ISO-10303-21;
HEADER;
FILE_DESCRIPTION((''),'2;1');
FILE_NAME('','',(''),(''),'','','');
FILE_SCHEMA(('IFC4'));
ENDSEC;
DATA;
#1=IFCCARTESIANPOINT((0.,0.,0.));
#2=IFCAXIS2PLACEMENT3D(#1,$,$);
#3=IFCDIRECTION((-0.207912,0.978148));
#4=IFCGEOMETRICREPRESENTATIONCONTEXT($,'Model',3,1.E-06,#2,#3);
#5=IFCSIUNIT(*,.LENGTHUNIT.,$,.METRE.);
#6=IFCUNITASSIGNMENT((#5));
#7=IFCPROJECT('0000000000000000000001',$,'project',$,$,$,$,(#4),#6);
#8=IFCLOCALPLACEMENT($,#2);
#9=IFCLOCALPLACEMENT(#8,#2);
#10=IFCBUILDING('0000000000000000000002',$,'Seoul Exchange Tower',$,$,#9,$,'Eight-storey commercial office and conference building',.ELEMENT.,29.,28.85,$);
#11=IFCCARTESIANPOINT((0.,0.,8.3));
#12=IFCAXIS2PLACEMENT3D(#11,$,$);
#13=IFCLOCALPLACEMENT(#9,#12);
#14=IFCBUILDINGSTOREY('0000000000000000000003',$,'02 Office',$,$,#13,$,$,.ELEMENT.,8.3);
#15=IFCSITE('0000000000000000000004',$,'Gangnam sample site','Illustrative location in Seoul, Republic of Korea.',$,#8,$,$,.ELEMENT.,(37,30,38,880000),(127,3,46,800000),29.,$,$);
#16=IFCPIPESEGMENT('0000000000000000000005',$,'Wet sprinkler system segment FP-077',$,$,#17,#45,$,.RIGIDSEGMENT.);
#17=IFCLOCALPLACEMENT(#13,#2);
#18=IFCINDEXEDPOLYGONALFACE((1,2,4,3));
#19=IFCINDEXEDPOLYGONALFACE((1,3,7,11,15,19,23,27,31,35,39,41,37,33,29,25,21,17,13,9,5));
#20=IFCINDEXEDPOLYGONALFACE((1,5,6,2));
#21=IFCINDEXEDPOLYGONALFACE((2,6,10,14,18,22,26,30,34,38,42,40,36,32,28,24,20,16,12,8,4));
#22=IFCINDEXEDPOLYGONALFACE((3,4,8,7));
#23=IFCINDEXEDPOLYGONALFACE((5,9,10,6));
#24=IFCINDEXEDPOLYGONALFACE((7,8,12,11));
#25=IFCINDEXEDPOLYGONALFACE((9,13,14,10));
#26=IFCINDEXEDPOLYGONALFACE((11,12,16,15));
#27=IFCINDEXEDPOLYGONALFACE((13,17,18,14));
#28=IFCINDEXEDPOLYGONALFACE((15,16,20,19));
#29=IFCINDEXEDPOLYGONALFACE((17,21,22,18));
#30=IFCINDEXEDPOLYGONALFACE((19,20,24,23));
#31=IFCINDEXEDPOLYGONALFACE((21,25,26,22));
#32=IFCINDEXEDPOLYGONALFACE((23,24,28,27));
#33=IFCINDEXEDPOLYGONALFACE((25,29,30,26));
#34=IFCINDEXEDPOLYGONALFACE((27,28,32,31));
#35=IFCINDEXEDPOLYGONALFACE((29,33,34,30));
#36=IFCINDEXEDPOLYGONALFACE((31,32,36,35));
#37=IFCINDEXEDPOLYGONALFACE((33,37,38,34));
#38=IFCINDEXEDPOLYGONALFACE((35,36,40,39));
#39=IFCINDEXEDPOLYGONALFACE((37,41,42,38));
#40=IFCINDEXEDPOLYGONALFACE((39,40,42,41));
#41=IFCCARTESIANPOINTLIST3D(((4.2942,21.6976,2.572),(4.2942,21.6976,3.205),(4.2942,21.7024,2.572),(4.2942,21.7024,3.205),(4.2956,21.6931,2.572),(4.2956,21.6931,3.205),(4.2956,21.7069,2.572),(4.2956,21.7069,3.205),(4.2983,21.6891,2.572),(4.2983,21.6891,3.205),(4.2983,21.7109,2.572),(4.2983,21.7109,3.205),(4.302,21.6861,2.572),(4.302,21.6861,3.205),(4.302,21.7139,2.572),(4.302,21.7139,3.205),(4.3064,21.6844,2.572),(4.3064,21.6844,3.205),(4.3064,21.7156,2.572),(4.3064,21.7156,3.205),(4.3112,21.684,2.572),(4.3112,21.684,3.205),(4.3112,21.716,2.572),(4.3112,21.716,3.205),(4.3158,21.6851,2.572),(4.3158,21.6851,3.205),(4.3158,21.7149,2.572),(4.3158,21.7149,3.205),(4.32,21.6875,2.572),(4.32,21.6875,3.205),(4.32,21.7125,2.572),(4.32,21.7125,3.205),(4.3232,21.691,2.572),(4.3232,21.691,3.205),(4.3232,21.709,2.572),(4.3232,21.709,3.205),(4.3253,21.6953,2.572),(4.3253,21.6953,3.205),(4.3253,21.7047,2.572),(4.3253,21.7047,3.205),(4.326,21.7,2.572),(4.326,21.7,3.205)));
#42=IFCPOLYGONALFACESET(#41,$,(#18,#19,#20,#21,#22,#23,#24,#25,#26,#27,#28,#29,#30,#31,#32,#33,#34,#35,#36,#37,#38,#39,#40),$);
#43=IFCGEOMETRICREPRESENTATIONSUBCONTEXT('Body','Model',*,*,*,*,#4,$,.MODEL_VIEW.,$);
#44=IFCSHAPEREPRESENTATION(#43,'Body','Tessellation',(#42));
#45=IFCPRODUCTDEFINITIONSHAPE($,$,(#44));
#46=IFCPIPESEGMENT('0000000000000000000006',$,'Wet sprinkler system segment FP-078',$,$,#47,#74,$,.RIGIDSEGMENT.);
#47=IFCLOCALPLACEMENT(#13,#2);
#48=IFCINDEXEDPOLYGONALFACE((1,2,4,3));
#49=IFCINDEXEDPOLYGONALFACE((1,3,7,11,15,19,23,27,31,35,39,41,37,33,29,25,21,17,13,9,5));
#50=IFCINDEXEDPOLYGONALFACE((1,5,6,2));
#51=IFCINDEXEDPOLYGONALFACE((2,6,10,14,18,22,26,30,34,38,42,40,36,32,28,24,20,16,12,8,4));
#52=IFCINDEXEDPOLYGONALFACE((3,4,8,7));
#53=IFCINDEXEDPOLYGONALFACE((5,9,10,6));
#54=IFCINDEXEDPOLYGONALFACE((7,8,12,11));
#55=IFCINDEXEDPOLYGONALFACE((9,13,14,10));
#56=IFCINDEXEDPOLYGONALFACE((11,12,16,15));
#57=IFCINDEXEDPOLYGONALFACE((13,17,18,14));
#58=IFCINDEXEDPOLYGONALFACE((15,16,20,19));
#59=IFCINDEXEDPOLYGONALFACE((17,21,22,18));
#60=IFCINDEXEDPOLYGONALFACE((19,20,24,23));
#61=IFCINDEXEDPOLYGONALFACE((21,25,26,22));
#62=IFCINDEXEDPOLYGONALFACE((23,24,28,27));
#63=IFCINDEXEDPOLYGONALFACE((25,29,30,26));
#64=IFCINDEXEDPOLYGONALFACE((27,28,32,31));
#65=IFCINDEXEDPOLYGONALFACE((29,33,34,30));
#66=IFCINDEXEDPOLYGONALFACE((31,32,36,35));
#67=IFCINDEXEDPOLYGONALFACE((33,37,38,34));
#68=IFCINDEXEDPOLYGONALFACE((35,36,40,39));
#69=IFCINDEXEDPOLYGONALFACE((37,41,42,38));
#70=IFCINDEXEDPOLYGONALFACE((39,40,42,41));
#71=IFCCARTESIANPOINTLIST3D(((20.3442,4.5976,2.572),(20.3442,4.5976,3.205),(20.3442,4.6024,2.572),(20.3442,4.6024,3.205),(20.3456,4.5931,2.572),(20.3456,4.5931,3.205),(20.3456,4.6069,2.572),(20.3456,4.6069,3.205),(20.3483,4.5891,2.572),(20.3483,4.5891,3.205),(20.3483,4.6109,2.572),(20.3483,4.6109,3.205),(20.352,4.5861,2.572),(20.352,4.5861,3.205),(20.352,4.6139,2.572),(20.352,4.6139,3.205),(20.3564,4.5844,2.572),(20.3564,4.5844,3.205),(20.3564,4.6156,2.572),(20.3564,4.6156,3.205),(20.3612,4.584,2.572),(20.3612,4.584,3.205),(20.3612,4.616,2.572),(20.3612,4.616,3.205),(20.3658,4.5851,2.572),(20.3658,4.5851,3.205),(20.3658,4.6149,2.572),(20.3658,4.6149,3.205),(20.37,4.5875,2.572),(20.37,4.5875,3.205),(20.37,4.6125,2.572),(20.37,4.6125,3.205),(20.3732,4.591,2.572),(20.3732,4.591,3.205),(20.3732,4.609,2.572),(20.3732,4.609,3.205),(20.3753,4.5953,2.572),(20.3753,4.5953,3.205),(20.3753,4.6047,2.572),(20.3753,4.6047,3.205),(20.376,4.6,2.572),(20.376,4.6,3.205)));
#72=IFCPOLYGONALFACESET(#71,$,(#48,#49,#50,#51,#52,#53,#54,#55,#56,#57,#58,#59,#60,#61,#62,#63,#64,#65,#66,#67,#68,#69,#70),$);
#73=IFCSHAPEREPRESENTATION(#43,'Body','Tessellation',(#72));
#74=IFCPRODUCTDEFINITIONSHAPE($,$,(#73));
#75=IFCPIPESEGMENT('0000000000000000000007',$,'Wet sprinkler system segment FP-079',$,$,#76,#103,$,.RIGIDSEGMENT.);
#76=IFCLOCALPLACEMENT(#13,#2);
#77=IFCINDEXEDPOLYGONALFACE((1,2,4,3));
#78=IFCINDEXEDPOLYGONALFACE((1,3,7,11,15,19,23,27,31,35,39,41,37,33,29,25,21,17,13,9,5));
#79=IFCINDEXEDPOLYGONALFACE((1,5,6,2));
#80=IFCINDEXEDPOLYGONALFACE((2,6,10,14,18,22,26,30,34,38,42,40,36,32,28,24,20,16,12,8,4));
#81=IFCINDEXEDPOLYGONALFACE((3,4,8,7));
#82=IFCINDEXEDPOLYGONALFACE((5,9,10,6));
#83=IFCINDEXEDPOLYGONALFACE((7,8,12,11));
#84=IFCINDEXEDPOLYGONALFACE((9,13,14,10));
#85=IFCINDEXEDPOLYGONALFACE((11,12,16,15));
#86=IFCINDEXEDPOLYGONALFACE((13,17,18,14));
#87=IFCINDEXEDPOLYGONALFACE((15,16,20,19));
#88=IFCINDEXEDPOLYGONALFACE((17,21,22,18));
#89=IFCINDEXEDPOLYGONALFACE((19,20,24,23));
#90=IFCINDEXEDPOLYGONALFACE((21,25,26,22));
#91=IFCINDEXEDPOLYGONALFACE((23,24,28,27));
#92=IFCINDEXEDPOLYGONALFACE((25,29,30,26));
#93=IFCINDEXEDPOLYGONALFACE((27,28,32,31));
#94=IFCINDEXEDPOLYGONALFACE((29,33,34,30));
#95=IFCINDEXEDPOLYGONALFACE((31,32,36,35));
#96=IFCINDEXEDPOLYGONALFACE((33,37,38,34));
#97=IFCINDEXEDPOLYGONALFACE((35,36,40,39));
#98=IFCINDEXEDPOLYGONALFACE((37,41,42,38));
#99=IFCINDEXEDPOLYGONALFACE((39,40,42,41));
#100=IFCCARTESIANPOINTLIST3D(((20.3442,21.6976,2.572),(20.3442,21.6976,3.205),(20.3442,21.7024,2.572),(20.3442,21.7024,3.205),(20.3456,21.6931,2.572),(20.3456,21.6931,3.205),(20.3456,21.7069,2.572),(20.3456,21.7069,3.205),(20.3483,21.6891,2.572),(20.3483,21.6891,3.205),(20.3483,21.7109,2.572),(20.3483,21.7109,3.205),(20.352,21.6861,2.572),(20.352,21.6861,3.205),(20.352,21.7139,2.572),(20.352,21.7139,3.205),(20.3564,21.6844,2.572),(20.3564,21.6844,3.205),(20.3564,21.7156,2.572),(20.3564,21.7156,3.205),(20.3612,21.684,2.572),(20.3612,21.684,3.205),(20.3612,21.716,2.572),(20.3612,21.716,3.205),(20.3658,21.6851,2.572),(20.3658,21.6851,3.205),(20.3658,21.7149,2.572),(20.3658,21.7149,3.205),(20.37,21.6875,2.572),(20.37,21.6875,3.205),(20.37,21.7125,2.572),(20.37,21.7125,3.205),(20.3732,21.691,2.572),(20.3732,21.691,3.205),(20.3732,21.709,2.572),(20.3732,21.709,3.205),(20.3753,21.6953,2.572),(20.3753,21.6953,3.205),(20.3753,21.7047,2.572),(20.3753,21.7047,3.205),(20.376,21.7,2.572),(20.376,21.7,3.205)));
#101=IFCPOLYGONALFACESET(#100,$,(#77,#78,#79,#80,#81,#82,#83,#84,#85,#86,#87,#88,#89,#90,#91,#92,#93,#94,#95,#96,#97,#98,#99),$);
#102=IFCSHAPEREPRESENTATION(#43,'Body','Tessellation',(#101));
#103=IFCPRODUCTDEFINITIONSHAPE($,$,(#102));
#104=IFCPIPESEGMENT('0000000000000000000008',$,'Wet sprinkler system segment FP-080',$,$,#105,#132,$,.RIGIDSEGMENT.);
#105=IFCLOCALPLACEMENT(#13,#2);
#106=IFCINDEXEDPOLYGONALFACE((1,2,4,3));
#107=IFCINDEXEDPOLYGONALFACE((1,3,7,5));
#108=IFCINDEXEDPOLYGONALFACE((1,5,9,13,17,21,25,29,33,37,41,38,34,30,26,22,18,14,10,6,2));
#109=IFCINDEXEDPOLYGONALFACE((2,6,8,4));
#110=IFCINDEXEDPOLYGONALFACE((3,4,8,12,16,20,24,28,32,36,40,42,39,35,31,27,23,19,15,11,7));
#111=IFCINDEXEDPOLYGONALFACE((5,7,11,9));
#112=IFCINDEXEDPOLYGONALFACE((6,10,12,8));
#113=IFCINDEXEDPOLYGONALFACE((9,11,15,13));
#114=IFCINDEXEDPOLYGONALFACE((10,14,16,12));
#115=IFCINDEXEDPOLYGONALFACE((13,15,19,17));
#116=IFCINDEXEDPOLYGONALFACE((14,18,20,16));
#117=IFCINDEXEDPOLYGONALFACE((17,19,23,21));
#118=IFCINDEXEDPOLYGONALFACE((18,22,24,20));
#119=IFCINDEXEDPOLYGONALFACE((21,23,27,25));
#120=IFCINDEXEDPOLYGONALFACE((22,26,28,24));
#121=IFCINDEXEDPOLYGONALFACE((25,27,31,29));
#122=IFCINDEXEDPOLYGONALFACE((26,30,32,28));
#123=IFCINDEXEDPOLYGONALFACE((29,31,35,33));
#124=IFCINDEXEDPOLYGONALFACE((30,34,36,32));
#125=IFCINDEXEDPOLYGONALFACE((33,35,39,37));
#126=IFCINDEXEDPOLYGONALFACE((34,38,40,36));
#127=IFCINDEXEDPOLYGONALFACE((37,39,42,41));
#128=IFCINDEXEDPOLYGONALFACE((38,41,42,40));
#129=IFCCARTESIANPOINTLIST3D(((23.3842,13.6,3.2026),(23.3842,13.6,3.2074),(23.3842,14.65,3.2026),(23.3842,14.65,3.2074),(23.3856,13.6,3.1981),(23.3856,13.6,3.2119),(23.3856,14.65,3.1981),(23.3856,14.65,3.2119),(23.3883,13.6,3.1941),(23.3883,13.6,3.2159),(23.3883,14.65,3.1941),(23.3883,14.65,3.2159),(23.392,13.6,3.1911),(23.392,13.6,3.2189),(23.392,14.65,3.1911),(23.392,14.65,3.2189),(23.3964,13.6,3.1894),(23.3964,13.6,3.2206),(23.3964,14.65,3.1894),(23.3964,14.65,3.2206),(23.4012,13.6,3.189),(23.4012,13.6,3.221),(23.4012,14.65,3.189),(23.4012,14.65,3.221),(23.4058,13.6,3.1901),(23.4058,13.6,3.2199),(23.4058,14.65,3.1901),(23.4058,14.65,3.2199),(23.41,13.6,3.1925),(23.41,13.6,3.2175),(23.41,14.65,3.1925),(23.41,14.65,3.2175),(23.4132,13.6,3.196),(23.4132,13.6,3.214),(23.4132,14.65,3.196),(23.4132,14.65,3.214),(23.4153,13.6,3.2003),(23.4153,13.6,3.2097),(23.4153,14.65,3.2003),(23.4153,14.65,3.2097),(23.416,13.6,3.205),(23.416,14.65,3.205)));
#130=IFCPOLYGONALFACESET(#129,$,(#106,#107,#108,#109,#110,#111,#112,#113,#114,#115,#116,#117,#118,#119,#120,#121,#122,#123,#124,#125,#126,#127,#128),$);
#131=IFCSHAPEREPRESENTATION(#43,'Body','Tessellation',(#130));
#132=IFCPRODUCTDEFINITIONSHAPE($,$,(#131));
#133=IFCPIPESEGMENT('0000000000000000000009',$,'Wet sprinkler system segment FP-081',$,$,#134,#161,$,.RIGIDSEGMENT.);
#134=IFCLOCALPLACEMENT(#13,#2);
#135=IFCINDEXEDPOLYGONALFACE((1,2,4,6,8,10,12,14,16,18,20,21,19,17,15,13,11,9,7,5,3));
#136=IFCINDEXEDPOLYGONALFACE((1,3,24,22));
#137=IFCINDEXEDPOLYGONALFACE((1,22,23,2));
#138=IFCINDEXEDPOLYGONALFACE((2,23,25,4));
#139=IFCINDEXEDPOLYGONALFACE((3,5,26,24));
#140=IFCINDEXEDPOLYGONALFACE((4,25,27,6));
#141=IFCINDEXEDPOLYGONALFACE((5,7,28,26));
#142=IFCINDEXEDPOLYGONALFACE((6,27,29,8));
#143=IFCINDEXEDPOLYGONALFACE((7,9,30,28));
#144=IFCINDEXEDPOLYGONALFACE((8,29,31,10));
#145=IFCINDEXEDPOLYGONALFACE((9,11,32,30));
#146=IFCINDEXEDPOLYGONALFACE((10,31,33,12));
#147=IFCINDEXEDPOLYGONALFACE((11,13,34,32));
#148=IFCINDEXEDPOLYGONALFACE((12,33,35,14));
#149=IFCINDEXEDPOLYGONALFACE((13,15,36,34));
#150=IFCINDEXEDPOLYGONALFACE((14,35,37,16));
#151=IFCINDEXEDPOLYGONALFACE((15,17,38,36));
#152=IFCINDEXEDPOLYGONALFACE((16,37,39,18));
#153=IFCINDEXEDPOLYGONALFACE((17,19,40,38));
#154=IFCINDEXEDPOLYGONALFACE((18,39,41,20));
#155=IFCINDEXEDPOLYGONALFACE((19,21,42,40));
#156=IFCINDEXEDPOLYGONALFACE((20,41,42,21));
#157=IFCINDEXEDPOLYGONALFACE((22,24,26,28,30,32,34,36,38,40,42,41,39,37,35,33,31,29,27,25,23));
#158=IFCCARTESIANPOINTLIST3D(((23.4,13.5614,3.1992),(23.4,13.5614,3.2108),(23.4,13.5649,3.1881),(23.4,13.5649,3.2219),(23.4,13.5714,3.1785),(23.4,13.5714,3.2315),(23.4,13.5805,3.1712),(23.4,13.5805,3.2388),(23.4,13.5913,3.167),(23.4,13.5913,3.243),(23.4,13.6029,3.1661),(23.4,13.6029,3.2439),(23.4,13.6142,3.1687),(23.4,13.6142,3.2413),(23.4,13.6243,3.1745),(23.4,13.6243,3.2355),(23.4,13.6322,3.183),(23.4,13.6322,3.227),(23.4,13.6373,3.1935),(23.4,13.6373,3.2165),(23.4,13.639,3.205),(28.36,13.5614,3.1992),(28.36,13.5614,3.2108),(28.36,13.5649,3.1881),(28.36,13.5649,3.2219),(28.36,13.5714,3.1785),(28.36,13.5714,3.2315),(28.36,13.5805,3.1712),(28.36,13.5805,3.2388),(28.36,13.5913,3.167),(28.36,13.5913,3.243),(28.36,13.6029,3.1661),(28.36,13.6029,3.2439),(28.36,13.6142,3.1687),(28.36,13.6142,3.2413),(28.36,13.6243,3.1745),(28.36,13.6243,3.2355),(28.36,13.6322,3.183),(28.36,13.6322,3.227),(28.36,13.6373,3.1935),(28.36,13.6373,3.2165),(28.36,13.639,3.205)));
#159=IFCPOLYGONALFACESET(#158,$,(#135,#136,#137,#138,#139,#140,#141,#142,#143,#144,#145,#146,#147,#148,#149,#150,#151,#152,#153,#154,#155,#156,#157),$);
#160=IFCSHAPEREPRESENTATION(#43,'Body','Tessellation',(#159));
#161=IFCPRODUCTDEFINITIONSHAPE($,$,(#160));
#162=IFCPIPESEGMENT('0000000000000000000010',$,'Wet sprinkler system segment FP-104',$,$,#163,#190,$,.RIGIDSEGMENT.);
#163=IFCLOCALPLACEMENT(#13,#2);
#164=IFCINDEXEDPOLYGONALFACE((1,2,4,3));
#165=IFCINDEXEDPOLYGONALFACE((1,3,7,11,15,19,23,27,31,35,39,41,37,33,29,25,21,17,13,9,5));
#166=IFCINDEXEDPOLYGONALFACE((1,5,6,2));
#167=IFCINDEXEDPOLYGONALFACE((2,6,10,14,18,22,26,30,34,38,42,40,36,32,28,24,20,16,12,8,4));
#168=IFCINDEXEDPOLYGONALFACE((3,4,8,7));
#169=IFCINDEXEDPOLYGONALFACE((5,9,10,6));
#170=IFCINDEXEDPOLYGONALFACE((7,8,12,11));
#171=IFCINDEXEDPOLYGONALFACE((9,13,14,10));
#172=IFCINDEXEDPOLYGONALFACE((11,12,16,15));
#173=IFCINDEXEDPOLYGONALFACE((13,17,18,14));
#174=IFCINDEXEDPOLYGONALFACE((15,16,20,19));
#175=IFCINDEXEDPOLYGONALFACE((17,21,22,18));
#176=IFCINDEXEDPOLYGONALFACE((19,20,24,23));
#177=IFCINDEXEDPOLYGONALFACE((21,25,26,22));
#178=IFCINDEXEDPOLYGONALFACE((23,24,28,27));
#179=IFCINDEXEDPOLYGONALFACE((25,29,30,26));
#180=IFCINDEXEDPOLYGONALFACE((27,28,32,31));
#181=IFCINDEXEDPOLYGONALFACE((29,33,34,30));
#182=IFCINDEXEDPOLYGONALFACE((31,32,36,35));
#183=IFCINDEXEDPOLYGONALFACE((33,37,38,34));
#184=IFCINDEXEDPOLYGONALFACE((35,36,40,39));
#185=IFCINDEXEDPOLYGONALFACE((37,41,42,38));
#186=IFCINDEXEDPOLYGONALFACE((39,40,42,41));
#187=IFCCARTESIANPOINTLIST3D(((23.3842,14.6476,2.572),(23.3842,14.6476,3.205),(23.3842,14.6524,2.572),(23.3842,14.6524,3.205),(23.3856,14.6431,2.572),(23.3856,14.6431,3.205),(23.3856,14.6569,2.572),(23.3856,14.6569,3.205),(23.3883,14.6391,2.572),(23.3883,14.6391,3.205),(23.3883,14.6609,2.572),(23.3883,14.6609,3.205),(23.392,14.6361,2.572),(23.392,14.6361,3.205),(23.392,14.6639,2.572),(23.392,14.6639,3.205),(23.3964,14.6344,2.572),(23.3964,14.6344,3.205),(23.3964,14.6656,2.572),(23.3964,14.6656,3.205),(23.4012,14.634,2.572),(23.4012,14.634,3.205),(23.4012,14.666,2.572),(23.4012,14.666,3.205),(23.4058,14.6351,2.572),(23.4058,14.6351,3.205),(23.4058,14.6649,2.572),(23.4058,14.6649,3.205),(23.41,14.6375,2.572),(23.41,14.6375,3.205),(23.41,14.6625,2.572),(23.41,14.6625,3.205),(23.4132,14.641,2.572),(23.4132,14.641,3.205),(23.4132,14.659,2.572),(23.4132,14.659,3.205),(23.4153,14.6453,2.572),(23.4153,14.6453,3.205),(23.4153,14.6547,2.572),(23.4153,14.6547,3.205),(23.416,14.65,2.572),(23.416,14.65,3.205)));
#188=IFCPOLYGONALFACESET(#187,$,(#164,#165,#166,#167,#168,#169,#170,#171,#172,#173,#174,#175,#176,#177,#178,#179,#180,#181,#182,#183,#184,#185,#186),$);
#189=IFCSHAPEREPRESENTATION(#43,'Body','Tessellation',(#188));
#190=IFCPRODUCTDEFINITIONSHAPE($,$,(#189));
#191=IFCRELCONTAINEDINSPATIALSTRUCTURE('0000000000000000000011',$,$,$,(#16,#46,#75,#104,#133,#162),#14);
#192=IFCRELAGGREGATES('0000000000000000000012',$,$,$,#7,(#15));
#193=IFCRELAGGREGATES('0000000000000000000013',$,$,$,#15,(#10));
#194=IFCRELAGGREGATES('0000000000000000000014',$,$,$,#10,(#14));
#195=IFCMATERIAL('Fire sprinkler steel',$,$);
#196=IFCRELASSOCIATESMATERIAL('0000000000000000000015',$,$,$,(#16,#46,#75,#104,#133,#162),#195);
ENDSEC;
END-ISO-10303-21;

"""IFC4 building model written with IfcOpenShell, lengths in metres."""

from ifc_helpers import new_model, si_unit, direction, frame, origin, place, context, subcontext, project, spatial, circle, extrude, material, element, save


model = new_model("IFC4")

# Units and contexts
model_context = context("Model", 3, precision=1e-06, world=origin(), true_north=direction((-0.207912, 0.978148)))
body_context = subcontext(model_context, "Body", "Model", "MODEL_VIEW")
ifc_project = project(units=[si_unit("LENGTHUNIT", "METRE")], contexts=[model_context])

# Site, building, storey
site_placement = place(None, origin())
site = spatial("IfcSite", under=ifc_project, at=site_placement, Name="Gangnam sample site", Description="Illustrative location in Seoul, Republic of Korea.", CompositionType="ELEMENT", RefLatitude=(37, 30, 38, 880000), RefLongitude=(127, 3, 46, 800000), RefElevation=29.0)
building_placement = place(site_placement, origin())
building = spatial("IfcBuilding", under=site, at=building_placement, Name="Seoul Exchange Tower", LongName="Eight-storey commercial office and conference building", CompositionType="ELEMENT", ElevationOfRefHeight=29.0, ElevationOfTerrain=28.85)
storey_placement = place(building_placement, frame((0.0, 0.0, 8.3)))
storey = spatial("IfcBuildingStorey", under=building, at=storey_placement, Name="02 Office", CompositionType="ELEMENT", Elevation=8.3)

# Shared definitions
ifc_material = material(Name="Fire sprinkler steel")
placement = place(storey_placement, origin())

# Pipe segments
element("IfcPipeSegment", 1, at=placement, inside=storey, material=ifc_material, Name="Wet sprinkler system segment FP-077", PredefinedType="RIGIDSEGMENT", context=body_context, shape_type="SweptSolid", body=[
    extrude(circle(Radius=0.016), frame((4.31, 21.7, 3.205), z_axis=(0.0, 0.0, -1.0), x_axis=(1.0, 0.0, 0.0)), (0.0, 0.0, 1.0), 0.633),
])
element("IfcPipeSegment", 2, at=placement, inside=storey, material=ifc_material, Name="Wet sprinkler system segment FP-078", PredefinedType="RIGIDSEGMENT", context=body_context, shape_type="SweptSolid", body=[
    extrude(circle(Radius=0.016), frame((20.36, 4.6, 3.205), z_axis=(0.0, 0.0, -1.0), x_axis=(1.0, 0.0, 0.0)), (0.0, 0.0, 1.0), 0.633),
])
element("IfcPipeSegment", 3, at=placement, inside=storey, material=ifc_material, Name="Wet sprinkler system segment FP-079", PredefinedType="RIGIDSEGMENT", context=body_context, shape_type="SweptSolid", body=[
    extrude(circle(Radius=0.016), frame((20.36, 21.7, 3.205), z_axis=(0.0, 0.0, -1.0), x_axis=(1.0, 0.0, 0.0)), (0.0, 0.0, 1.0), 0.633),
])
element("IfcPipeSegment", 4, at=placement, inside=storey, material=ifc_material, Name="Wet sprinkler system segment FP-080", PredefinedType="RIGIDSEGMENT", context=body_context, shape_type="SweptSolid", body=[
    extrude(circle(Radius=0.016), frame((23.4, 13.6, 3.205), z_axis=(0.0, 1.0, 0.0), x_axis=(1.0, 0.0, 0.0)), (0.0, 0.0, 1.0), 1.05),
])
element("IfcPipeSegment", 5, at=placement, inside=storey, material=ifc_material, Name="Wet sprinkler system segment FP-081", PredefinedType="RIGIDSEGMENT", context=body_context, shape_type="SweptSolid", body=[
    extrude(circle(Radius=0.039), frame((23.4, 13.6, 3.205), z_axis=(1.0, 0.0, 0.0), x_axis=(0.0, 1.0, 0.0)), (0.0, 0.0, 1.0), 4.96),
])
element("IfcPipeSegment", 6, at=placement, inside=storey, material=ifc_material, Name="Wet sprinkler system segment FP-104", PredefinedType="RIGIDSEGMENT", context=body_context, shape_type="SweptSolid", body=[
    extrude(circle(Radius=0.016), frame((23.4, 14.65, 3.205), z_axis=(0.0, 0.0, -1.0), x_axis=(1.0, 0.0, 0.0)), (0.0, 0.0, 1.0), 0.633),
])

save(model, "model.ifc")
